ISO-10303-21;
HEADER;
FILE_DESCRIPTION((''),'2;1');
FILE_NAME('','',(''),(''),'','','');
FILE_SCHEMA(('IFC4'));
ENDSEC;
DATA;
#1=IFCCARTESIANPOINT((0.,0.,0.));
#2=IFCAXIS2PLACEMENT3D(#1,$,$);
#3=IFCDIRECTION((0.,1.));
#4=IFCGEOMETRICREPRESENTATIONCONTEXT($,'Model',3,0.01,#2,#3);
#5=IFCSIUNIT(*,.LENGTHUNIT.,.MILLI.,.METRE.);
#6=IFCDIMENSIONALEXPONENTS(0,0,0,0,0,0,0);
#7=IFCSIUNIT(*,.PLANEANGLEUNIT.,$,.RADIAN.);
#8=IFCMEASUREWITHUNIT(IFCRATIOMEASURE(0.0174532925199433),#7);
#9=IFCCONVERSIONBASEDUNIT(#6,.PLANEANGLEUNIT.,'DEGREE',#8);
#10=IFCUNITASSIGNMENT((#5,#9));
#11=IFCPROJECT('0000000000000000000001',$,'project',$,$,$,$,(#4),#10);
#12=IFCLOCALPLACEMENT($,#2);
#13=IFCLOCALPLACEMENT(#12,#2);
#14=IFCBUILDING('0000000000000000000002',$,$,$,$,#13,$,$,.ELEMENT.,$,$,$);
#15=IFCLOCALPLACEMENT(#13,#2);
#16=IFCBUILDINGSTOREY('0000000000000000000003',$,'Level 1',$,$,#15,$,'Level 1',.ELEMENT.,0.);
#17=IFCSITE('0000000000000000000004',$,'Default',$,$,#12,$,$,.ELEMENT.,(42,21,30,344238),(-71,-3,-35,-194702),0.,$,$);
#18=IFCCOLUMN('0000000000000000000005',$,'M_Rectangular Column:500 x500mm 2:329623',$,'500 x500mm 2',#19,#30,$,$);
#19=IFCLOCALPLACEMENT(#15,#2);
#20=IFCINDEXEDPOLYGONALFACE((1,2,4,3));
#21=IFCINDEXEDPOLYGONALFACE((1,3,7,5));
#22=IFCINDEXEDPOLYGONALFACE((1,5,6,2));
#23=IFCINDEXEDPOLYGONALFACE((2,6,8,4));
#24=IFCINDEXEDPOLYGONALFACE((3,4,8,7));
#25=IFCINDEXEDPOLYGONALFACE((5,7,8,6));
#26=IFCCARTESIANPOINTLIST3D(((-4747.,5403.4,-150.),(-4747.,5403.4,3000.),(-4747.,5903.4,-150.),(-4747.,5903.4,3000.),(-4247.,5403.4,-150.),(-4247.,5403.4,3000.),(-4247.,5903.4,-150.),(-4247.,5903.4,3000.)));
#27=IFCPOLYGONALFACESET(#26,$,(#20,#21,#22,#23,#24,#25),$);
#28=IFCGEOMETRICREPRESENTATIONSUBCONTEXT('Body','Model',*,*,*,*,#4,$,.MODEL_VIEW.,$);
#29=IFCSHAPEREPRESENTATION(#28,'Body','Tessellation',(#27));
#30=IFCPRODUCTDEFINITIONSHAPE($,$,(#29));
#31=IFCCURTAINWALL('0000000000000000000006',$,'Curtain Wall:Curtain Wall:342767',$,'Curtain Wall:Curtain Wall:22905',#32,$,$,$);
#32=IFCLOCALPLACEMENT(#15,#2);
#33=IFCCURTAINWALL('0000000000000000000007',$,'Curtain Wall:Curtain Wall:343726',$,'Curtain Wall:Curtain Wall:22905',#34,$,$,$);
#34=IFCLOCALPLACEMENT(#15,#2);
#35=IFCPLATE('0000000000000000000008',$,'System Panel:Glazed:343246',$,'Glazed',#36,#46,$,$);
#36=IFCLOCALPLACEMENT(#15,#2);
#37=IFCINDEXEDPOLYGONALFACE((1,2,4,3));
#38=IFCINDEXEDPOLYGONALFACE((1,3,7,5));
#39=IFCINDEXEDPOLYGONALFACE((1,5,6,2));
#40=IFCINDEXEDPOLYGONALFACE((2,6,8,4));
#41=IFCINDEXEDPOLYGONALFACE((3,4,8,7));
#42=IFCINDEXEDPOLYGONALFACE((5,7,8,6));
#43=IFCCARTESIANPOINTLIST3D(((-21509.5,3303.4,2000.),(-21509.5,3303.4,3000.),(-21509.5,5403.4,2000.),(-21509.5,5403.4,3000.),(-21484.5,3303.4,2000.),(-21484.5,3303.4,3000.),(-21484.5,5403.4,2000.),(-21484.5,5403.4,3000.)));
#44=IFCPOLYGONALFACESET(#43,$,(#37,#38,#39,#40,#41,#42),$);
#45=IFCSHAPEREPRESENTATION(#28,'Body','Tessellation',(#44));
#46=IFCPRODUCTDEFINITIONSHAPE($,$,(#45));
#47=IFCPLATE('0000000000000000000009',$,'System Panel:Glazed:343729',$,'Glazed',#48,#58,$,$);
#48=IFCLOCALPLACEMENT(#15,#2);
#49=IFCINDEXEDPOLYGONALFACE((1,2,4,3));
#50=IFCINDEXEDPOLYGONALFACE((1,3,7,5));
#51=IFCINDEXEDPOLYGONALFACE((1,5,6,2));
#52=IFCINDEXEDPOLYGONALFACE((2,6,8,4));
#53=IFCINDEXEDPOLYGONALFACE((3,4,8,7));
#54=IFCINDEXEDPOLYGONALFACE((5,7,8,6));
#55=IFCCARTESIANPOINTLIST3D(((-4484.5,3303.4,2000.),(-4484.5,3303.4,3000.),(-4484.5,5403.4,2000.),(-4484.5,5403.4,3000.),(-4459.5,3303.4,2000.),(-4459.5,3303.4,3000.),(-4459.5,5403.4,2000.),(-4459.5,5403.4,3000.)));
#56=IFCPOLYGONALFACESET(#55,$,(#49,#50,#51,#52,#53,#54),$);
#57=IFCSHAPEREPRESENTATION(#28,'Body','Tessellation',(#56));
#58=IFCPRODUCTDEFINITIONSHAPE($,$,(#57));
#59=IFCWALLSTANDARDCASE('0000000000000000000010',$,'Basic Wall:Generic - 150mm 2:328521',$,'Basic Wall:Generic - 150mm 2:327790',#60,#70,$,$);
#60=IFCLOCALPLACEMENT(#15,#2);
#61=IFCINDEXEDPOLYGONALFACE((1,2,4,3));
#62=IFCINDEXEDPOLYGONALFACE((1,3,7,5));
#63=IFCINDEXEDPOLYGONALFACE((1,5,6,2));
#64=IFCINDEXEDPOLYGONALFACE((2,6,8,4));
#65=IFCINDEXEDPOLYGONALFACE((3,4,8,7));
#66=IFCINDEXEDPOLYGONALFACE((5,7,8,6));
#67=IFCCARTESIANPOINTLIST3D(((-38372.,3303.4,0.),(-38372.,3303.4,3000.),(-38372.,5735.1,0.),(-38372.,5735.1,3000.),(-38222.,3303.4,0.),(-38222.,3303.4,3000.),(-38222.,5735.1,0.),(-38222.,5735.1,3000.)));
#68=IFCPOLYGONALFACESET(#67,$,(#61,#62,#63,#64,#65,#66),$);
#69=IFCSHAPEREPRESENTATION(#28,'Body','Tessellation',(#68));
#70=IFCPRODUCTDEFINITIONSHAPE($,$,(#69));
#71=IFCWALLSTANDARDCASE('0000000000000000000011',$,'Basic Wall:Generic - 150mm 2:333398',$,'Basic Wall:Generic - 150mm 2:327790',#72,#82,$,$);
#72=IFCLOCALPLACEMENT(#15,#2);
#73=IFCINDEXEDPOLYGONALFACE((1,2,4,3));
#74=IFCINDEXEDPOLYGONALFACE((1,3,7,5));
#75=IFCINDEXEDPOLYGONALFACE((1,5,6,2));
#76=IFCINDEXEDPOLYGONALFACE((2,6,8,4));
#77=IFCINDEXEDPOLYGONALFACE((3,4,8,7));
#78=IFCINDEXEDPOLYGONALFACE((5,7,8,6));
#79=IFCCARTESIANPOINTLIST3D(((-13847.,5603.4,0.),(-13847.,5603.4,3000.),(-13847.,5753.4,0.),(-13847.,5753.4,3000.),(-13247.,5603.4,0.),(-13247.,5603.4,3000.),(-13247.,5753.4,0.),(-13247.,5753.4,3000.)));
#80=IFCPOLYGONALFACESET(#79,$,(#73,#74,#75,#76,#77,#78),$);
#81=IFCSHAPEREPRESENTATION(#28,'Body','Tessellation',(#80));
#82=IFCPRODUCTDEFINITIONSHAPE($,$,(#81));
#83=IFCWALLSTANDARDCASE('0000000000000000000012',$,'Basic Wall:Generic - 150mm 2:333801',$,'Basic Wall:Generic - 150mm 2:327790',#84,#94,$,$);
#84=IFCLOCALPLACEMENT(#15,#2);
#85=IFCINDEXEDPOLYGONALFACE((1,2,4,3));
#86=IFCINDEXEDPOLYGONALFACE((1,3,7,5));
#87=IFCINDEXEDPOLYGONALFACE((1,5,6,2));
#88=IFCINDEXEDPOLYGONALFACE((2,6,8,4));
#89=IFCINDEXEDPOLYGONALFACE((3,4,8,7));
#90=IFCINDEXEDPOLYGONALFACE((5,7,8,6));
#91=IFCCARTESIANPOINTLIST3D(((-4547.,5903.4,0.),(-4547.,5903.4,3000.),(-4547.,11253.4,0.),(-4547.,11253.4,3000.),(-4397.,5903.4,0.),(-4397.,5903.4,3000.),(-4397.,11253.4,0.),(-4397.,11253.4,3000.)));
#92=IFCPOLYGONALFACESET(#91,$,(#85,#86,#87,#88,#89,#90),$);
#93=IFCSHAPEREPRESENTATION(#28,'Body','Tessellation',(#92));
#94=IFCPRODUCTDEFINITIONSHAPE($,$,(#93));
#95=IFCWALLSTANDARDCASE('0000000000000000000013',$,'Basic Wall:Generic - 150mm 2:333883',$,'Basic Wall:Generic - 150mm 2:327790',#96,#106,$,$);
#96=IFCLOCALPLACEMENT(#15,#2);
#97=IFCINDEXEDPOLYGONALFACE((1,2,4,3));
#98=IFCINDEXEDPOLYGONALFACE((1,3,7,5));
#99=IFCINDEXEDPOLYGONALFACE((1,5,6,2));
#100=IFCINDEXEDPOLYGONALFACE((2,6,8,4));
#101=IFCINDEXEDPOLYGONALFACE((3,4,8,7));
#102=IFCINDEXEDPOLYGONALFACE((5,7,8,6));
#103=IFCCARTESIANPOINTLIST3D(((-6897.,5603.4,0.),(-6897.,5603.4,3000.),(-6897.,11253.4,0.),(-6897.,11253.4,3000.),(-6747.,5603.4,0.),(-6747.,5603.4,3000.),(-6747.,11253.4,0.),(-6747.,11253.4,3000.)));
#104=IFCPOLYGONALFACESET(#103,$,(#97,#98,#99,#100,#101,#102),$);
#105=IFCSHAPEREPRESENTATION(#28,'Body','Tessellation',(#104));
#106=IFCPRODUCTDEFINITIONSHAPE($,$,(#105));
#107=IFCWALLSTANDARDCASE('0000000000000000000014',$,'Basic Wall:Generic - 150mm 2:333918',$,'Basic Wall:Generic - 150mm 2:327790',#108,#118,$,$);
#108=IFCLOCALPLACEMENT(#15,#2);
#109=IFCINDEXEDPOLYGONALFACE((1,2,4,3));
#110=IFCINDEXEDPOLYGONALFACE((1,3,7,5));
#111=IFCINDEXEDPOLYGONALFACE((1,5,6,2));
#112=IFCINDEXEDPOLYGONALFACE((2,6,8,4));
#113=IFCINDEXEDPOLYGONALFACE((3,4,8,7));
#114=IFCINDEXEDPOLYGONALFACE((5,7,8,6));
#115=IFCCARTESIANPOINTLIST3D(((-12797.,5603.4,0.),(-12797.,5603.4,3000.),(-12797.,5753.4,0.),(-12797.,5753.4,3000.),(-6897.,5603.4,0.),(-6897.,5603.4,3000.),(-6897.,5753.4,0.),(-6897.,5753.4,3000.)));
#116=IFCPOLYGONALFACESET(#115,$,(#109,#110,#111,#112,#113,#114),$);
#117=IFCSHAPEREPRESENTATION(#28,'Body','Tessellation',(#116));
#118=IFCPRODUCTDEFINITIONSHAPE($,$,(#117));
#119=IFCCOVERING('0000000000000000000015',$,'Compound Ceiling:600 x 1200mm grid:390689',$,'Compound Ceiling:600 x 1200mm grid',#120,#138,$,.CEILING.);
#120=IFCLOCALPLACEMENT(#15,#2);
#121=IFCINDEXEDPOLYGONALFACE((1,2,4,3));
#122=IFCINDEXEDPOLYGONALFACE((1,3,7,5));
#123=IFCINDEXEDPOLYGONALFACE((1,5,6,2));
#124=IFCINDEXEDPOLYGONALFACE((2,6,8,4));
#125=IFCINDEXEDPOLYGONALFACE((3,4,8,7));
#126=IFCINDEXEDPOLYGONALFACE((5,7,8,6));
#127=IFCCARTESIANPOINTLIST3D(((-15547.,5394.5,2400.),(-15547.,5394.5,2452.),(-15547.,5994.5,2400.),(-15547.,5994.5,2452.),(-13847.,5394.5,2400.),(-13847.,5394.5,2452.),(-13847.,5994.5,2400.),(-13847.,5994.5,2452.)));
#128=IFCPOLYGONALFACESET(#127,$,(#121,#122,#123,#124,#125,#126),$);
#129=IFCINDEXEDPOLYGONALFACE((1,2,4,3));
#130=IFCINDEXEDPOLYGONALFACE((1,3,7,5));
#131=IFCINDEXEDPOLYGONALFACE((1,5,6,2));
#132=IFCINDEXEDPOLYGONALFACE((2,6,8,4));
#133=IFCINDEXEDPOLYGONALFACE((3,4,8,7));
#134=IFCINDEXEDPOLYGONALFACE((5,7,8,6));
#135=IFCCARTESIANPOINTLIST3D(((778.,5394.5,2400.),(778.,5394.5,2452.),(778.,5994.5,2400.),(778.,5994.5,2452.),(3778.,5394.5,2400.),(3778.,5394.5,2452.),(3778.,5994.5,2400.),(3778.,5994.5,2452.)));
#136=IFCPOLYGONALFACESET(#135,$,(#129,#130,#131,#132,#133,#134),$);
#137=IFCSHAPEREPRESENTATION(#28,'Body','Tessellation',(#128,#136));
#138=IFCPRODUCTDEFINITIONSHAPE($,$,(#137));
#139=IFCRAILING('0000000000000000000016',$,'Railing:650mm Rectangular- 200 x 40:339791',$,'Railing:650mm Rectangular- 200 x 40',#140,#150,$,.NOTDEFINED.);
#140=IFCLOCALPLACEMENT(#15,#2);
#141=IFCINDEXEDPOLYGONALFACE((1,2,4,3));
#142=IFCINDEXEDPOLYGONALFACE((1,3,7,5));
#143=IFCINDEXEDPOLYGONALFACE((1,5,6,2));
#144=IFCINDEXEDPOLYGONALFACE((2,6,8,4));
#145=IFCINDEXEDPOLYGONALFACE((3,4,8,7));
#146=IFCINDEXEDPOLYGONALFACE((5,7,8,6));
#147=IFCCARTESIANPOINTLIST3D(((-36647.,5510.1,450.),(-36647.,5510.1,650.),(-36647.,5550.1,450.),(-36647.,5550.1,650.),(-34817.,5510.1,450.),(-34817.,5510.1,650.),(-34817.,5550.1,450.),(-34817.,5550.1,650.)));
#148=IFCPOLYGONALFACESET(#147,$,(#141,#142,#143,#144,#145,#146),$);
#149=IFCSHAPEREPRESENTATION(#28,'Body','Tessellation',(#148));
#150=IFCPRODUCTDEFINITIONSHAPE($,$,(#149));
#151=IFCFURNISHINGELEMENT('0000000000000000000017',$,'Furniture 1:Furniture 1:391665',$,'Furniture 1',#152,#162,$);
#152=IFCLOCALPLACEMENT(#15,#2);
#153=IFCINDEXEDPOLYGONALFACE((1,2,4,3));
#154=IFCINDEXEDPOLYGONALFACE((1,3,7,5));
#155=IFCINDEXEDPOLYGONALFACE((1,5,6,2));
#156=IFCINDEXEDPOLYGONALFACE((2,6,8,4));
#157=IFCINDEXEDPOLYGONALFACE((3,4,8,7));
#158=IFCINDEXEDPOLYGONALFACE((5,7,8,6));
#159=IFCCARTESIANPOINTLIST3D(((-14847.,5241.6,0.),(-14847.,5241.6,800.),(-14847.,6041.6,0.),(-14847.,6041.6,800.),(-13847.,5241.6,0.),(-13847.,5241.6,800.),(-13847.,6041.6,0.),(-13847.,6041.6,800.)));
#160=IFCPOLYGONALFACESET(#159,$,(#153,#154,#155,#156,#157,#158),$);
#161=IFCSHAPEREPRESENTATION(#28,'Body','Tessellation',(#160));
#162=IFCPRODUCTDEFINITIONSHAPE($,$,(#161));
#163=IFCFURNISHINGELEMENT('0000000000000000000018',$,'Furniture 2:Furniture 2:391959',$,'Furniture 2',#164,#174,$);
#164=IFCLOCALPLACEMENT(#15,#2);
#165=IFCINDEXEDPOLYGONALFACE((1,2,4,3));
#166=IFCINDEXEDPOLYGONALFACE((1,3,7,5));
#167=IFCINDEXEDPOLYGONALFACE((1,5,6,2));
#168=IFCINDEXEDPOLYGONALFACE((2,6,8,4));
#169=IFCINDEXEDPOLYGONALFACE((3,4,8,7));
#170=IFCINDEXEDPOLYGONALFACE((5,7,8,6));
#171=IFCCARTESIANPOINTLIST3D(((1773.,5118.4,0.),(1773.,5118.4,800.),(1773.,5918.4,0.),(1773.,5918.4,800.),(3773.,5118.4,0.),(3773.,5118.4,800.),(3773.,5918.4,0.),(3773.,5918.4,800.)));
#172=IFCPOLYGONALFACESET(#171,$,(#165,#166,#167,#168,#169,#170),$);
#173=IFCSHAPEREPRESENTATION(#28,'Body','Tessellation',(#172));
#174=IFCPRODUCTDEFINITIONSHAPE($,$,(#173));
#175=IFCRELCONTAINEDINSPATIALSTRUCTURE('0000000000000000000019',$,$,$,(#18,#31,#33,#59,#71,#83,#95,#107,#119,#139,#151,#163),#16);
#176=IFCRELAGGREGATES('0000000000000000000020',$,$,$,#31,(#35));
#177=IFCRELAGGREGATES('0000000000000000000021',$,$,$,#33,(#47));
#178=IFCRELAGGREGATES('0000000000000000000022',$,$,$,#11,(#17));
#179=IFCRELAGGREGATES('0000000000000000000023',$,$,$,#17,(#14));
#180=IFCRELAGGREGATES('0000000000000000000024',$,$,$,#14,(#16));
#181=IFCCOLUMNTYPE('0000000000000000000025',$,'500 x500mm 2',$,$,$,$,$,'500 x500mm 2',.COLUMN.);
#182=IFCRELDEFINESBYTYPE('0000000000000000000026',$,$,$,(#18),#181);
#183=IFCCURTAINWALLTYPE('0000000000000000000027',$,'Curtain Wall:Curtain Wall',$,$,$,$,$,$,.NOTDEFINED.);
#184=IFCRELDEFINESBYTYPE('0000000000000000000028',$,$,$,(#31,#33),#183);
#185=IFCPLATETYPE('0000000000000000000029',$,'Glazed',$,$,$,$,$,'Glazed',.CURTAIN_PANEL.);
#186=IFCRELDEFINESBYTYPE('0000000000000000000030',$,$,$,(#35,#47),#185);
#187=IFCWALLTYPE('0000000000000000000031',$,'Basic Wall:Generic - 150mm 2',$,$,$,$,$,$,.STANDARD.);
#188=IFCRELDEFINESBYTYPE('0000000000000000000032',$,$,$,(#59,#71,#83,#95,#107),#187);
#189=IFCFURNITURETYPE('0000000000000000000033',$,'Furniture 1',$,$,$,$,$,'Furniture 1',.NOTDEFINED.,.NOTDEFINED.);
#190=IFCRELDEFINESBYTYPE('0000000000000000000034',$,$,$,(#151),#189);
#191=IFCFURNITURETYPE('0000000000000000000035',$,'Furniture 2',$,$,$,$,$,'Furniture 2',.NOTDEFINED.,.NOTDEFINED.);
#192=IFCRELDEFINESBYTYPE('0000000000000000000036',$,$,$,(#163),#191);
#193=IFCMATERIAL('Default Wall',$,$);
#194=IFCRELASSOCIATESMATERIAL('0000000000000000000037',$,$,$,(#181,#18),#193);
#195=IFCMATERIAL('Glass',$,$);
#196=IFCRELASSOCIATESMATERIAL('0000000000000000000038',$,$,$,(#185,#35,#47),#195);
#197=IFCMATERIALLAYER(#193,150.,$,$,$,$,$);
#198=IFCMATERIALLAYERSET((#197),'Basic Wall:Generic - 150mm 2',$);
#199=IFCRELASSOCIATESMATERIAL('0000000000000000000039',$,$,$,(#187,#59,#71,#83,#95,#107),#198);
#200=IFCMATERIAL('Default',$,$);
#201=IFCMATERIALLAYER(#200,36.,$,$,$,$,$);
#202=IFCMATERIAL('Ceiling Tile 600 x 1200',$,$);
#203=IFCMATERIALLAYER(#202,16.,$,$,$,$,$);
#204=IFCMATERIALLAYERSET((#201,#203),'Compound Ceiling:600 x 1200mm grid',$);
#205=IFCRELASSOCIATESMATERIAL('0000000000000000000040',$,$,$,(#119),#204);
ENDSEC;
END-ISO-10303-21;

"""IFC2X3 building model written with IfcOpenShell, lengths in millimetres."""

from ifc_helpers import new_model, entity, si_unit, converted_unit, direction, frame, frame_2d, origin, place, context, subcontext, project, spatial, rectangle, extrude, source, transform, mapped, material, layer, layer_set, layer_usage, type_object, type_shapes, element, aggregate, save


model = new_model("IFC2X3")

# Units and contexts
model_context = context("Model", 3, precision=0.01, world=origin(), true_north=direction((0.0, 1.0)))
body_context = subcontext(model_context, "Body", "Model", "MODEL_VIEW")
ifc_project = project(units=[si_unit("LENGTHUNIT", "METRE", prefix="MILLI"), converted_unit("PLANEANGLEUNIT", "DEGREE", entity("IfcRatioMeasure", 0.0174532925199433), si_unit("PLANEANGLEUNIT", "RADIAN"), dimensions=[0, 0, 0, 0, 0, 0, 0])], contexts=[model_context])

# Site, building, storey
site_placement = place(None, origin())
site = spatial("IfcSite", under=ifc_project, at=site_placement, Name="Default", CompositionType="ELEMENT", RefLatitude=(42, 21, 30, 344238), RefLongitude=(-71, -3, -35, -194702), RefElevation=0.0)
building_placement = place(site_placement, origin())
building = spatial("IfcBuilding", under=site, at=building_placement, CompositionType="ELEMENT")
storey_placement = place(building_placement, origin())
storey = spatial("IfcBuildingStorey", under=building, at=storey_placement, Name="Level 1", LongName="Level 1", CompositionType="ELEMENT", Elevation=0.0)

# Column
ifc_material_1 = material(Name="Default Wall")
column_type = type_object("IfcColumnType", Name="500 x500mm 2", ElementType="500 x500mm 2", PredefinedType="COLUMN", material=ifc_material_1)
shared_shape_1 = source(origin(), body_context, "Body", "SweptSolid", [
    extrude(rectangle(XDim=500.0, YDim=500.0, at=frame_2d((0.0, 0.0), x_axis=(1.0, 0.0))), frame((-4497.0, 5653.4, -150.0), z_axis=(0.0, 0.0, 1.0), x_axis=(0.0, -1.0, 0.0)), (0.0, 0.0, 1.0), 3150.0),
])
type_shapes(column_type, [shared_shape_1])
column_placement = place(storey_placement, origin())
element("IfcColumn", 1, at=column_placement, inside=storey, type_object=column_type, material=ifc_material_1, Name="M_Rectangular Column:500 x500mm 2:329623", ObjectType="500 x500mm 2", context=body_context, shape_type="MappedRepresentation", body=[
    mapped(shared_shape_1, transform((0.0, 0.0, 0.0), scale=1.0)),
])

# Curtain walls
curtain_wall_type = type_object("IfcCurtainWallType", Name="Curtain Wall:Curtain Wall", PredefinedType="NOTDEFINED")
curtain_wall_1_placement = place(storey_placement, origin())
curtain_wall_1 = element("IfcCurtainWall", 2, at=curtain_wall_1_placement, inside=storey, type_object=curtain_wall_type, Name="Curtain Wall:Curtain Wall:342767", ObjectType="Curtain Wall:Curtain Wall:22905")
ifc_material_2 = material(Name="Glass")
curtain_wall_2_placement = place(storey_placement, origin())
curtain_wall_2 = element("IfcCurtainWall", 3, at=curtain_wall_2_placement, inside=storey, type_object=curtain_wall_type, Name="Curtain Wall:Curtain Wall:343726", ObjectType="Curtain Wall:Curtain Wall:22905")

# Plates
plate_type_1 = type_object("IfcPlateType", Name="Glazed", ElementType="Glazed", PredefinedType="CURTAIN_PANEL", material=ifc_material_2)
shared_shape_2 = source(origin(), body_context, "Body", "SweptSolid", [
    extrude(rectangle(XDim=1000.0, YDim=2100.0, at=frame_2d((0.0, 0.0), x_axis=(1.0, 0.0))), frame((0.0, 24.5, 500.0), z_axis=(0.0, 1.0, 0.0), x_axis=(0.0, 0.0, 1.0)), (0.0, 0.0, 1.0), 25.0),
])
type_shapes(plate_type_1, [shared_shape_2])
plate_1_placement = place(curtain_wall_1_placement, frame((-21534.0, 4353.4, 2000.0), z_axis=(0.0, 0.0, 1.0), x_axis=(0.0, -1.0, 0.0)))
plate_1 = element("IfcPlate", 4, at=plate_1_placement, type_object=plate_type_1, material=ifc_material_2, Name="System Panel:Glazed:343246", ObjectType="Glazed", context=body_context, shape_type="MappedRepresentation", body=[
    mapped(shared_shape_2, transform((0.0, 0.0, 0.0), scale=1.0)),
])
aggregate(curtain_wall_1, [plate_1])
plate_2_placement = place(curtain_wall_2_placement, frame((-4509.0, 4353.4, 2000.0), z_axis=(0.0, 0.0, 1.0), x_axis=(0.0, -1.0, 0.0)))
plate_2 = element("IfcPlate", 5, at=plate_2_placement, type_object=plate_type_1, material=ifc_material_2, Name="System Panel:Glazed:343729", ObjectType="Glazed", context=body_context, shape_type="MappedRepresentation", body=[
    mapped(shared_shape_2, transform((0.0, 0.0, 0.0), scale=1.0)),
])
aggregate(curtain_wall_2, [plate_2])

# Wall
ifc_layer_1 = layer(ifc_material_1, 150.0)
ifc_layer_set_1 = layer_set([ifc_layer_1], Name="Basic Wall:Generic - 150mm 2")
ifc_layer_usage_1 = layer_usage(ifc_layer_set_1, "AXIS2", "NEGATIVE", 75.0)
wall_type = type_object("IfcWallType", Name="Basic Wall:Generic - 150mm 2", PredefinedType="STANDARD", material=ifc_layer_set_1)
wall_1_placement = place(storey_placement, frame((-38297.0, 3303.4, 0.0), z_axis=(0.0, 0.0, 1.0), x_axis=(0.0, 1.0, 0.0)))
element("IfcWallStandardCase", 6, at=wall_1_placement, inside=storey, type_object=wall_type, material=ifc_layer_usage_1, Name="Basic Wall:Generic - 150mm 2:328521", ObjectType="Basic Wall:Generic - 150mm 2:327790", context=body_context, shape_type="SweptSolid", body=[
    extrude(rectangle(XDim=2431.7, YDim=150.0, at=frame_2d((1215.9, 0.0), x_axis=(-1.0, 0.0))), origin(), (0.0, 0.0, 1.0), 3000.0),
])

# Walls
ifc_layer_usage_2 = layer_usage(ifc_layer_set_1, "AXIS2", "POSITIVE", -75.0)
wall_2_placement = place(storey_placement, frame((-13847.0, 5678.4, 0.0)))
element("IfcWallStandardCase", 7, at=wall_2_placement, inside=storey, type_object=wall_type, material=ifc_layer_usage_2, Name="Basic Wall:Generic - 150mm 2:333398", ObjectType="Basic Wall:Generic - 150mm 2:327790", context=body_context, shape_type="SweptSolid", body=[
    extrude(rectangle(XDim=600.0, YDim=150.0, at=frame_2d((300.0, 0.0), x_axis=(-1.0, 0.0))), origin(), (0.0, 0.0, 1.0), 3000.0),
])
ifc_layer_usage_3 = layer_usage(ifc_layer_set_1, "AXIS2", "NEGATIVE", 75.0)
wall_3_placement = place(storey_placement, frame((-4472.0, 5903.4, 0.0), z_axis=(0.0, 0.0, 1.0), x_axis=(0.0, 1.0, 0.0)))
element("IfcWallStandardCase", 8, at=wall_3_placement, inside=storey, type_object=wall_type, material=ifc_layer_usage_3, Name="Basic Wall:Generic - 150mm 2:333801", ObjectType="Basic Wall:Generic - 150mm 2:327790", context=body_context, shape_type="SweptSolid", body=[
    extrude(rectangle(XDim=5350.0, YDim=150.0, at=frame_2d((2675.0, 0.0), x_axis=(-1.0, 0.0))), origin(), (0.0, 0.0, 1.0), 3000.0),
])
ifc_layer_usage_4 = layer_usage(ifc_layer_set_1, "AXIS2", "NEGATIVE", 75.0)
wall_4_placement = place(storey_placement, frame((-6822.0, 11253.4, 0.0), z_axis=(0.0, 0.0, 1.0), x_axis=(0.0, -1.0, 0.0)))
element("IfcWallStandardCase", 9, at=wall_4_placement, inside=storey, type_object=wall_type, material=ifc_layer_usage_4, Name="Basic Wall:Generic - 150mm 2:333883", ObjectType="Basic Wall:Generic - 150mm 2:327790", context=body_context, shape_type="SweptSolid", body=[
    extrude(rectangle(XDim=5650.0, YDim=150.0, at=frame_2d((2825.0, 0.0), x_axis=(-1.0, 0.0))), origin(), (0.0, 0.0, 1.0), 3000.0),
])
ifc_layer_usage_5 = layer_usage(ifc_layer_set_1, "AXIS2", "NEGATIVE", 75.0)
wall_5_placement = place(storey_placement, frame((-6897.0, 5678.4, 0.0), z_axis=(0.0, 0.0, 1.0), x_axis=(-1.0, 0.0, 0.0)))
element("IfcWallStandardCase", 10, at=wall_5_placement, inside=storey, type_object=wall_type, material=ifc_layer_usage_5, Name="Basic Wall:Generic - 150mm 2:333918", ObjectType="Basic Wall:Generic - 150mm 2:327790", context=body_context, shape_type="SweptSolid", body=[
    extrude(rectangle(XDim=5900.0, YDim=150.0, at=frame_2d((2950.0, 0.0), x_axis=(-1.0, 0.0))), origin(), (0.0, 0.0, 1.0), 3000.0),
])

# Covering
ifc_material_3 = material(Name="Default")
ifc_layer_2 = layer(ifc_material_3, 36.0)
ifc_material_4 = material(Name="Ceiling Tile 600 x 1200")
ifc_layer_3 = layer(ifc_material_4, 16.0)
ifc_layer_set_2 = layer_set([ifc_layer_2, ifc_layer_3], Name="Compound Ceiling:600 x 1200mm grid")
ifc_layer_usage_6 = layer_usage(ifc_layer_set_2, "AXIS3", "NEGATIVE", 0.0)
covering_1_placement = place(storey_placement, origin())
element("IfcCovering", 11, at=covering_1_placement, inside=storey, material=ifc_layer_usage_6, Name="Compound Ceiling:600 x 1200mm grid:390689", ObjectType="Compound Ceiling:600 x 1200mm grid", PredefinedType="CEILING", context=body_context, shape_type="SweptSolid", body=[
    extrude(rectangle(XDim=1700.0, YDim=600.0, at=frame_2d((0.0, 0.0), x_axis=(1.0, 0.0))), frame((-14697.0, 5694.5, 2400.0)), (0.0, 0.0, 1.0), 52.0),
    extrude(rectangle(XDim=3000.0, YDim=600.0, at=frame_2d((0.0, 0.0), x_axis=(1.0, 0.0))), frame((2278.0, 5694.5, 2400.0)), (0.0, 0.0, 1.0), 52.0),
])

# Railing
railing_placement = place(storey_placement, origin())
element("IfcRailing", 12, at=railing_placement, inside=storey, Name="Railing:650mm Rectangular- 200 x 40:339791", ObjectType="Railing:650mm Rectangular- 200 x 40", PredefinedType="NOTDEFINED", context=body_context, shape_type="SweptSolid", body=[
    extrude(rectangle(XDim=1830.0, YDim=40.0, at=frame_2d((0.0, 0.0), x_axis=(1.0, 0.0))), frame((-35732.0, 5530.1, 450.0)), (0.0, 0.0, 1.0), 200.0),
])

# Furnishing elements
furniture_type_1 = type_object("IfcFurnitureType", Name="Furniture 1", ElementType="Furniture 1", AssemblyPlace="NOTDEFINED")
shared_shape_3 = source(origin(), body_context, "Body", "SweptSolid", [
    extrude(rectangle(XDim=1000.0, YDim=800.0, at=frame_2d((0.0, 0.0), x_axis=(1.0, 0.0))), frame((-14347.0, 5641.6, 0.0)), (0.0, 0.0, 1.0), 800.0),
])
type_shapes(furniture_type_1, [shared_shape_3])
furnishing_1_placement = place(storey_placement, origin())
element("IfcFurnishingElement", 13, at=furnishing_1_placement, inside=storey, type_object=furniture_type_1, Name="Furniture 1:Furniture 1:391665", ObjectType="Furniture 1", context=body_context, shape_type="MappedRepresentation", body=[
    mapped(shared_shape_3, transform((0.0, 0.0, 0.0), scale=1.0)),
])
furniture_type_2 = type_object("IfcFurnitureType", Name="Furniture 2", ElementType="Furniture 2", AssemblyPlace="NOTDEFINED")
shared_shape_4 = source(origin(), body_context, "Body", "SweptSolid", [
    extrude(rectangle(XDim=2000.0, YDim=800.0, at=frame_2d((0.0, 0.0), x_axis=(1.0, 0.0))), frame((2773.0, 5518.4, 0.0)), (0.0, 0.0, 1.0), 800.0),
])
type_shapes(furniture_type_2, [shared_shape_4])
furnishing_2_placement = place(storey_placement, origin())
element("IfcFurnishingElement", 14, at=furnishing_2_placement, inside=storey, type_object=furniture_type_2, Name="Furniture 2:Furniture 2:391959", ObjectType="Furniture 2", context=body_context, shape_type="MappedRepresentation", body=[
    mapped(shared_shape_4, transform((0.0, 0.0, 0.0), scale=1.0)),
])

save(model, "model.ifc")
